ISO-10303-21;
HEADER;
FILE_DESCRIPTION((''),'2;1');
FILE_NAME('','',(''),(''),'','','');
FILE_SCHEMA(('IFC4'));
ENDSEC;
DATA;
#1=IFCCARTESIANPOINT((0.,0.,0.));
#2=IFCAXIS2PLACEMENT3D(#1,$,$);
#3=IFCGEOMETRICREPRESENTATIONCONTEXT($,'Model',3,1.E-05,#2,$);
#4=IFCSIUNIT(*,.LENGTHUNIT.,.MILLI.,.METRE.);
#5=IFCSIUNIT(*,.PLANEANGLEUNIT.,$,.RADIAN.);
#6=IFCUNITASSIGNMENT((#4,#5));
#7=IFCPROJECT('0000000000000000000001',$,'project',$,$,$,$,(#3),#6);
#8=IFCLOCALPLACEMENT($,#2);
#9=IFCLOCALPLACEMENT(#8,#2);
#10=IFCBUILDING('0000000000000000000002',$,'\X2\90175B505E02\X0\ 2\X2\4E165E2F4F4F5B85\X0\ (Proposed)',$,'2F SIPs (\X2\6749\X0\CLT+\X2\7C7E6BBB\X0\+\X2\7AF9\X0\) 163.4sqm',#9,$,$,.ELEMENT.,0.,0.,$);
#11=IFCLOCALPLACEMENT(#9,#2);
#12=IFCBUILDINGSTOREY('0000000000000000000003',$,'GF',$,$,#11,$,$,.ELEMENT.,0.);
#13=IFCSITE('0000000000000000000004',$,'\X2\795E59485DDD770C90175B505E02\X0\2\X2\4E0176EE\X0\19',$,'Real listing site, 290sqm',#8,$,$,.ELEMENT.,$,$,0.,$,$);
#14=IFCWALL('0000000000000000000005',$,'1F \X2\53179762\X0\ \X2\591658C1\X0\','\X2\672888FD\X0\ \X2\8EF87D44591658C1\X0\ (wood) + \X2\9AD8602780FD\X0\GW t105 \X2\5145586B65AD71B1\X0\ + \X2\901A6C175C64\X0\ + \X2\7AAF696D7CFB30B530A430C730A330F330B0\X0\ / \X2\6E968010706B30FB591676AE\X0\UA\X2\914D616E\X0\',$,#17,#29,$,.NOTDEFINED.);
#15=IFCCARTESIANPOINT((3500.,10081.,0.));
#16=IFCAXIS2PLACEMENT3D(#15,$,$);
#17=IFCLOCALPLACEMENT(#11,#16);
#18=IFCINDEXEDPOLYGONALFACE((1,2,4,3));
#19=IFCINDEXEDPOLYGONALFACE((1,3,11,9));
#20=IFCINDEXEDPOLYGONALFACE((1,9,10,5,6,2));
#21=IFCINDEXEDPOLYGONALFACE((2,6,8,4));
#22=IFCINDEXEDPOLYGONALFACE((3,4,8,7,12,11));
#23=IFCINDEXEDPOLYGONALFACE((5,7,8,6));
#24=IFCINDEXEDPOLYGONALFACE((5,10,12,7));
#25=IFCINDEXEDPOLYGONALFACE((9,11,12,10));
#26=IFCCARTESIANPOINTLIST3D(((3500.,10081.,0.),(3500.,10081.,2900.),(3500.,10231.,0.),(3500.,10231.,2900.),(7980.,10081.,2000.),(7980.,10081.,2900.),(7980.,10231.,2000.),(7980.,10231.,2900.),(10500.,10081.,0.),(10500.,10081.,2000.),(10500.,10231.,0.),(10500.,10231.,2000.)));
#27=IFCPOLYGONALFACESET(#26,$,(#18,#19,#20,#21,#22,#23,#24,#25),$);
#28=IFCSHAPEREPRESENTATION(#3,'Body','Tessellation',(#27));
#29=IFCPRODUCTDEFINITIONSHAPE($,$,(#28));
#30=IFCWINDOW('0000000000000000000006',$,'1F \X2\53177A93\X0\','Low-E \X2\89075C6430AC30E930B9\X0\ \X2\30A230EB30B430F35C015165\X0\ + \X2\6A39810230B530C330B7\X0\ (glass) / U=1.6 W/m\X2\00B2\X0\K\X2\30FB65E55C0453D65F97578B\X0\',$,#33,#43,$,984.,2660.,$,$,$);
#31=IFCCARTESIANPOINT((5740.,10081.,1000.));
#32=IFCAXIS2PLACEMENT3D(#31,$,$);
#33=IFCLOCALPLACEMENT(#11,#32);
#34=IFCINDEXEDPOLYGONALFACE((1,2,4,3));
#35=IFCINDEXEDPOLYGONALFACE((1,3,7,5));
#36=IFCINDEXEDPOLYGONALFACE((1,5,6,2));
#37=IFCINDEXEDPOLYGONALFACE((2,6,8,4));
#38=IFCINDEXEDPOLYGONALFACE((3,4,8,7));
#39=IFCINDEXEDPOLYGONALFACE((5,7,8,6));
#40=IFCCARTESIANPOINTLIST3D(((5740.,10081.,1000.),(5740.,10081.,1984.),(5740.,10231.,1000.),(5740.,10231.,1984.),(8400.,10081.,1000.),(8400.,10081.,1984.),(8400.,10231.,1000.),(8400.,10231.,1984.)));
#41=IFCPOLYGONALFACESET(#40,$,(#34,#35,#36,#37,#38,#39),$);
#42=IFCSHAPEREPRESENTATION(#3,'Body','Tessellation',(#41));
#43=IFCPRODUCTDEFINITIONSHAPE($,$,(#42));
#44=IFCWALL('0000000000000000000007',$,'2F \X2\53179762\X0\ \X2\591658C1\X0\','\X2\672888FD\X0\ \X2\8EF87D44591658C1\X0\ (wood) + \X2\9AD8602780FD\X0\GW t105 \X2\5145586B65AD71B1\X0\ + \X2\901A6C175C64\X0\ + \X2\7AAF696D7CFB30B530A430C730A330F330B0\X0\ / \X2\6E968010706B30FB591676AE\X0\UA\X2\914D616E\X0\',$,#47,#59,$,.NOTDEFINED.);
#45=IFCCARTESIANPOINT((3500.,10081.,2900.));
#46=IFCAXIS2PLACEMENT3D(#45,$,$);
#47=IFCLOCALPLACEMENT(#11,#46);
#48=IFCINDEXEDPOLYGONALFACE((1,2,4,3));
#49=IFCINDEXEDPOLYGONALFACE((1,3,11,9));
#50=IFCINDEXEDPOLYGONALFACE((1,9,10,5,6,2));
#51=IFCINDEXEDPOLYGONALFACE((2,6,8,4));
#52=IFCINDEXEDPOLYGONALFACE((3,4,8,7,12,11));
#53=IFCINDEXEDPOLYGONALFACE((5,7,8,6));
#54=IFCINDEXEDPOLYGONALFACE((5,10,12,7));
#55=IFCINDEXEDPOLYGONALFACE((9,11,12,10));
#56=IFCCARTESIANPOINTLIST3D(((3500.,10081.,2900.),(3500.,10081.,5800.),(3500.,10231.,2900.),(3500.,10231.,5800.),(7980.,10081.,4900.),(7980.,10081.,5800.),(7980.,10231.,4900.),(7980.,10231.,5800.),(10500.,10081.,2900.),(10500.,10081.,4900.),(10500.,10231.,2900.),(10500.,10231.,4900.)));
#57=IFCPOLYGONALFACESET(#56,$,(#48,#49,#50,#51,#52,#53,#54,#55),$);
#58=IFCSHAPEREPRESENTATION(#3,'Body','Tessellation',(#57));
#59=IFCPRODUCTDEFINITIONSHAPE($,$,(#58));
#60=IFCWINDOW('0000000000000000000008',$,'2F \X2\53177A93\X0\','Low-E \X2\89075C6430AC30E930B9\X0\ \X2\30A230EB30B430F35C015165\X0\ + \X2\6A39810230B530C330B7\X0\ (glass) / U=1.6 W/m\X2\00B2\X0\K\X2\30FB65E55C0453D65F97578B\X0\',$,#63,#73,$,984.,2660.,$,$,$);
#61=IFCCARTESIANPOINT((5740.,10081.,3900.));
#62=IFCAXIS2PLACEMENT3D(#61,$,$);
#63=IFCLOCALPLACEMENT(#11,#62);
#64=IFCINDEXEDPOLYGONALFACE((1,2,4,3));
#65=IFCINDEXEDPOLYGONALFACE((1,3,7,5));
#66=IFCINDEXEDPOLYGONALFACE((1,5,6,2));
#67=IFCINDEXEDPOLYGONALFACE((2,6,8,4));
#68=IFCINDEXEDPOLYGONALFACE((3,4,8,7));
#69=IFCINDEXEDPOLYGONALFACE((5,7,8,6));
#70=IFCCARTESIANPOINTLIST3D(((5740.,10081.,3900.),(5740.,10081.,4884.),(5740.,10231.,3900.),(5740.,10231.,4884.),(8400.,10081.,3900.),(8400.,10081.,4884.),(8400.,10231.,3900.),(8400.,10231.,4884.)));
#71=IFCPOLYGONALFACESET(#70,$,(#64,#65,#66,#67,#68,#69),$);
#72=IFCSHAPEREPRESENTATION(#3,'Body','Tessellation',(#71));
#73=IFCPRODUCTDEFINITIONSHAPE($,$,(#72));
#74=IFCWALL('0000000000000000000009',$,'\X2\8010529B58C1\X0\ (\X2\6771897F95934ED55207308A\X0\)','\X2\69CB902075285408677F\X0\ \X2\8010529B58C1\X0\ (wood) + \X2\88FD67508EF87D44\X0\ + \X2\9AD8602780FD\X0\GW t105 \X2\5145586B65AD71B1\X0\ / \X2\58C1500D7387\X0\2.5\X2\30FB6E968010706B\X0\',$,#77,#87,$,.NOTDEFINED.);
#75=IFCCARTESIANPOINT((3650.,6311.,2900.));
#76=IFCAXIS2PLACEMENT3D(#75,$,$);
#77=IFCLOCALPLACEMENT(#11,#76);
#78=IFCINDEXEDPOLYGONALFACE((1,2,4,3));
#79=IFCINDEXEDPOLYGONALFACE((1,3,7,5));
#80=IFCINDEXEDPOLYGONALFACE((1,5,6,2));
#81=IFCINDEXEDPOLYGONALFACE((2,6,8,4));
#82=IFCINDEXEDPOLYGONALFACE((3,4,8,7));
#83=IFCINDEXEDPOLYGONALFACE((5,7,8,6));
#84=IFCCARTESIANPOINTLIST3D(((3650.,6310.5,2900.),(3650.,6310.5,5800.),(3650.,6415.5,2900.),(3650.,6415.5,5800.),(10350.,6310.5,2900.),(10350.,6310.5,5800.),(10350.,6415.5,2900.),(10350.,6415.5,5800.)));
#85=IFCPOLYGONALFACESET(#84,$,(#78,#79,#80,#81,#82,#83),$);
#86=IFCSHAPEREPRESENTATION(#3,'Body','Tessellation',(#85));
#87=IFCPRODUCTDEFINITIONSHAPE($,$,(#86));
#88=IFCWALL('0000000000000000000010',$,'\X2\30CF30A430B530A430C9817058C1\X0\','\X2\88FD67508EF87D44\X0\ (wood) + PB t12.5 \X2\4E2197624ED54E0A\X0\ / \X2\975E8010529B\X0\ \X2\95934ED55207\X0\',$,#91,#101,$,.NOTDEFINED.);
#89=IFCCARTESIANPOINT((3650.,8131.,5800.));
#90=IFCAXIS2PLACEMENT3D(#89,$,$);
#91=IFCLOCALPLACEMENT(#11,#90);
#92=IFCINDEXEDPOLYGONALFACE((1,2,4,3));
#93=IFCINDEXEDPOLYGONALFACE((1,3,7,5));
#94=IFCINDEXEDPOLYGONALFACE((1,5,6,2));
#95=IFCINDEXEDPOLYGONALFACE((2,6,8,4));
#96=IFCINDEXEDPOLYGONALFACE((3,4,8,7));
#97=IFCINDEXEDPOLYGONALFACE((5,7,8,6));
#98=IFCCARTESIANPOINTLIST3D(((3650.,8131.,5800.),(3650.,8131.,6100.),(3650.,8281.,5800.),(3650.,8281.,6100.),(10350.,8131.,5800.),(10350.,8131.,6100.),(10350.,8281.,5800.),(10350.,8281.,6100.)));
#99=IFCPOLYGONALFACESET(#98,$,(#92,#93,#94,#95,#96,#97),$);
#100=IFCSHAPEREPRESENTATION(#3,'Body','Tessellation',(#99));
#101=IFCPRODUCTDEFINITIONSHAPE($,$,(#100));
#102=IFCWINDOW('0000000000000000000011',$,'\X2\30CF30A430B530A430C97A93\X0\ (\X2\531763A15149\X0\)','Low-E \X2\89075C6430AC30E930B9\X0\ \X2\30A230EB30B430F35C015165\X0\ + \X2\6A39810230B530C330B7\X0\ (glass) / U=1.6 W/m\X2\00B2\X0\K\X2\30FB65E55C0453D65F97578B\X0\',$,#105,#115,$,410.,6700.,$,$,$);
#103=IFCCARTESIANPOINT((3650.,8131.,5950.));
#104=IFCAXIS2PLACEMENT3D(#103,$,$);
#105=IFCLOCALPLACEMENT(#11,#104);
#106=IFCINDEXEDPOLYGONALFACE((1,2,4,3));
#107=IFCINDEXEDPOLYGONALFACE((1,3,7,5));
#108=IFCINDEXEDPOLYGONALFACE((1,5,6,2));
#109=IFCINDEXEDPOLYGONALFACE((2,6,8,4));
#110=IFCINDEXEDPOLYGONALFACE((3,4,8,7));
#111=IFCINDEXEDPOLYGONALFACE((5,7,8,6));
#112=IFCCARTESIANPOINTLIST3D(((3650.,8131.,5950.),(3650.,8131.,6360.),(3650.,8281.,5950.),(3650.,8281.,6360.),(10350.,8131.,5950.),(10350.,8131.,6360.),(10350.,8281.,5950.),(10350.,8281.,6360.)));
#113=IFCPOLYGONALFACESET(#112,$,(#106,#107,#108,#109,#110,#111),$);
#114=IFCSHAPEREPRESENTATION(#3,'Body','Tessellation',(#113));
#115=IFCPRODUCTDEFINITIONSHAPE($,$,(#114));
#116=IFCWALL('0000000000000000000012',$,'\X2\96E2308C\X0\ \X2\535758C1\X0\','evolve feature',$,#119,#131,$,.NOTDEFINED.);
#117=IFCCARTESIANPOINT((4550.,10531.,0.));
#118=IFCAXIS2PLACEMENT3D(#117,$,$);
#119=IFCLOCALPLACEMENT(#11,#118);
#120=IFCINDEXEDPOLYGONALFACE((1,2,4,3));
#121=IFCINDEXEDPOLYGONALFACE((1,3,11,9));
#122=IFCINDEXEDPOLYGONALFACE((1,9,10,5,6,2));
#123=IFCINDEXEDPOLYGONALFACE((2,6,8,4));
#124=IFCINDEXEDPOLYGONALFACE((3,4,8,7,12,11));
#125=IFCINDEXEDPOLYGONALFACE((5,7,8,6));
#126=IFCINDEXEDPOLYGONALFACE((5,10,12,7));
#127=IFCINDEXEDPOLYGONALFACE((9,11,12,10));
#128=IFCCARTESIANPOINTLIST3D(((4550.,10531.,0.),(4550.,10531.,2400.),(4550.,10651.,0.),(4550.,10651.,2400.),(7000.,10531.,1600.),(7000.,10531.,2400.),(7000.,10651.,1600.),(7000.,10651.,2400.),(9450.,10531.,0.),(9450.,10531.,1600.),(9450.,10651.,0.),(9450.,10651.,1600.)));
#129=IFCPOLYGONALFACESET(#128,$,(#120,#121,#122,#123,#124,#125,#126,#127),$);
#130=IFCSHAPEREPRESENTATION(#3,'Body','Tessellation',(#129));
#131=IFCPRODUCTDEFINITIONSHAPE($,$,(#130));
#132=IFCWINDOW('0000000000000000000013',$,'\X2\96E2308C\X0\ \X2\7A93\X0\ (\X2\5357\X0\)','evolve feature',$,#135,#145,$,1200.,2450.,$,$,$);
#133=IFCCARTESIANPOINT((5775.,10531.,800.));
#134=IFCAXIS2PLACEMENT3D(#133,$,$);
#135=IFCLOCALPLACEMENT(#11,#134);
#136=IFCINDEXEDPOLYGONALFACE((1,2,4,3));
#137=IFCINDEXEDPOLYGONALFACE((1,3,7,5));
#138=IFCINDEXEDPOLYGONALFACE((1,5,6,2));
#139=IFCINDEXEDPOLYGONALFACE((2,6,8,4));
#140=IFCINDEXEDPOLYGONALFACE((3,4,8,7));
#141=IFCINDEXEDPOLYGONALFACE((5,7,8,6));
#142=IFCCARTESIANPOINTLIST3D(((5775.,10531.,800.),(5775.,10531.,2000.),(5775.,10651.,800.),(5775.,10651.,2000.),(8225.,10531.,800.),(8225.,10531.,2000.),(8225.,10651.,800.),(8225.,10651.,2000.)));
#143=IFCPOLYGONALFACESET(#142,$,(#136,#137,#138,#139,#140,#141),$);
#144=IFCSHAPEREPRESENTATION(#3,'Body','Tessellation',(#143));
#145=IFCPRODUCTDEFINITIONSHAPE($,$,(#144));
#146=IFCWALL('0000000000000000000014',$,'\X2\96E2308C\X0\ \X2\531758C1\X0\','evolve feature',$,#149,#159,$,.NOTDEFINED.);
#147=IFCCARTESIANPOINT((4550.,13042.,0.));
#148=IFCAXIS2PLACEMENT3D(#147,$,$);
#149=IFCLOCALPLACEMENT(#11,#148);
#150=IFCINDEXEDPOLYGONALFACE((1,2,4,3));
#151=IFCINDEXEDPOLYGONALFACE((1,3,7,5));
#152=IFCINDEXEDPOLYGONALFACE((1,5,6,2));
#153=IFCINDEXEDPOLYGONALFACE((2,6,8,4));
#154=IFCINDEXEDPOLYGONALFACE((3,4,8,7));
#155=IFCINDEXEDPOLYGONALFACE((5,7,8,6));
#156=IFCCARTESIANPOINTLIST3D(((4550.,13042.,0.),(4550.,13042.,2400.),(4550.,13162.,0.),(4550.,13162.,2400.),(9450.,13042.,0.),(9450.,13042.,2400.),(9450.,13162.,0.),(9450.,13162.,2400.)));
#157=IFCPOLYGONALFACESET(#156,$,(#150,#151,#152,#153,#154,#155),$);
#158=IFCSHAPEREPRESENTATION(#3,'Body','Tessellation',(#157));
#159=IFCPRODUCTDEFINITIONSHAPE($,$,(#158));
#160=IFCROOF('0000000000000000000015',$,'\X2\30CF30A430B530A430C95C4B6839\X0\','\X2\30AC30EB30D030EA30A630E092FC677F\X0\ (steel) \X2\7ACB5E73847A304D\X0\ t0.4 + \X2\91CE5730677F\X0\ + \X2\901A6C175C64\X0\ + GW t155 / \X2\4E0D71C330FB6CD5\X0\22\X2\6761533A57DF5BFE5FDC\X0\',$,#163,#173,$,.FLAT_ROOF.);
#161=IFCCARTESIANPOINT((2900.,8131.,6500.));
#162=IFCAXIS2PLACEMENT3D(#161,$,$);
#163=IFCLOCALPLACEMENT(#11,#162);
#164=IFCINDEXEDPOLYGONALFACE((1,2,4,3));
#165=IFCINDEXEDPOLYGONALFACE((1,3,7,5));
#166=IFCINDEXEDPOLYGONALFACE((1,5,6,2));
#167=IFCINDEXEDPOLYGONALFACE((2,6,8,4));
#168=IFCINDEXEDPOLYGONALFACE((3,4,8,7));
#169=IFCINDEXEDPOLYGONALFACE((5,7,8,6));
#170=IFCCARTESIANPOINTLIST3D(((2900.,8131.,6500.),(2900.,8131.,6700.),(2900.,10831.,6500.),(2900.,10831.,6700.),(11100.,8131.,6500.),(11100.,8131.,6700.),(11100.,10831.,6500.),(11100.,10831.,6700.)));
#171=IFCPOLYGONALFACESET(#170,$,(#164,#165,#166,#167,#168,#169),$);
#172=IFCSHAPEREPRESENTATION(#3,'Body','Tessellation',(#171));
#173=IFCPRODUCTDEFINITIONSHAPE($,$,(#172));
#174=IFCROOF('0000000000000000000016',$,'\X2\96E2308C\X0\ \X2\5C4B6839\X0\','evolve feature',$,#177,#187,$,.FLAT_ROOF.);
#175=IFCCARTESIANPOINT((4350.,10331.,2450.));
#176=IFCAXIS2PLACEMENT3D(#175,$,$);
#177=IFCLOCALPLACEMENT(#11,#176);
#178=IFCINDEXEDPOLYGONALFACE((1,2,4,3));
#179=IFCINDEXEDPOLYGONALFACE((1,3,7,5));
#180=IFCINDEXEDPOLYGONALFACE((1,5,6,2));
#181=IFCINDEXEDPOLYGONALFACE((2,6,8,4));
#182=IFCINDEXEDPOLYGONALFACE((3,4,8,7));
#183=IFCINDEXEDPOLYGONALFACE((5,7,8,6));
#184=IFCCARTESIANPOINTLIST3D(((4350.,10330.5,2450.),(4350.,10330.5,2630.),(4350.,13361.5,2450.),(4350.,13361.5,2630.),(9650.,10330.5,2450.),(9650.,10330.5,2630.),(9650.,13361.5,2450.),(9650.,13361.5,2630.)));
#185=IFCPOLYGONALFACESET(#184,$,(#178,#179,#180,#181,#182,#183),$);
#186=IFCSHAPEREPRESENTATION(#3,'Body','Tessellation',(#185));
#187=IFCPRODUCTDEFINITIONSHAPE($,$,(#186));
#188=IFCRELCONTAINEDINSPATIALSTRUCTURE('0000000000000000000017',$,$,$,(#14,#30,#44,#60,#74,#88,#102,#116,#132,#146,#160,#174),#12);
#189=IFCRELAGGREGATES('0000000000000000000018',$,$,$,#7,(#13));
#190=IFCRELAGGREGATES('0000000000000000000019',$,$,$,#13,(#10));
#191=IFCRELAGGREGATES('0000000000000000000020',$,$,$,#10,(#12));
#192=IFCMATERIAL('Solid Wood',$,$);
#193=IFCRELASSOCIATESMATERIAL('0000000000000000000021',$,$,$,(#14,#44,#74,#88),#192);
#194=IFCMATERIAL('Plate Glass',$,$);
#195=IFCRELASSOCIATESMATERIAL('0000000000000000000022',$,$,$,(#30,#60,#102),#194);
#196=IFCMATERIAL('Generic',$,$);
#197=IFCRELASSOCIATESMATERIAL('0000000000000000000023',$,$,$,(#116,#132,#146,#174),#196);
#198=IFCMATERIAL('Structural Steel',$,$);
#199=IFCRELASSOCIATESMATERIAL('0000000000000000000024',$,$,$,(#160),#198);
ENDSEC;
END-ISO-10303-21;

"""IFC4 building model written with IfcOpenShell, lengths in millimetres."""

from ifc_helpers import new_model, si_unit, frame, frame_2d, origin, place, context, project, spatial, rectangle, extrude, material, element, fill, save


model = new_model("IFC4")

# Units and contexts
model_context = context("Model", 3, precision=1e-05, world=origin())
ifc_project = project(units=[si_unit("LENGTHUNIT", "METRE", prefix="MILLI"), si_unit("PLANEANGLEUNIT", "RADIAN")], contexts=[model_context])

# Site, building, storey
site_placement = place(None, origin())
site = spatial("IfcSite", under=ifc_project, at=site_placement, Name="神奈川県逗子市2丁目19", ObjectType="Real listing site, 290sqm", CompositionType="ELEMENT", RefElevation=0.0)
building_placement = place(site_placement, origin())
building = spatial("IfcBuilding", under=site, at=building_placement, Name="逗子市 2世帯住宅 (Proposed)", ObjectType="2F SIPs (杉CLT+籾殻+竹) 163.4sqm", CompositionType="ELEMENT", ElevationOfRefHeight=0.0, ElevationOfTerrain=0.0)
storey_placement = place(building_placement, origin())
storey = spatial("IfcBuildingStorey", under=building, at=storey_placement, Name="GF", CompositionType="ELEMENT", Elevation=0.0)

# Shared definitions
ifc_material_1 = material(Name="Generic")

# Wall, opening, window
ifc_material_2 = material(Name="Solid Wood")
wall_1_placement = place(storey_placement, frame((3500.0, 10081.0, 0.0)))
wall_1 = element("IfcWall", 1, at=wall_1_placement, inside=storey, material=ifc_material_2, Name="1F 北面 外壁", Description="木製 軸組外壁 (wood) + 高性能GW t105 充填断熱 + 通気層 + 窯業系サイディング / 準耐火・外皮UA配慮", PredefinedType="NOTDEFINED", context=model_context, shape_type="SweptSolid", body=[
    extrude(rectangle(XDim=7000.0, YDim=150.0, at=frame_2d((3500.0, 75.0))), frame((3500.0, 10081.0, 0.0)), (0.0, 0.0, 1.0), 2900.0),
])
opening_1_placement = place(storey_placement, frame((5740.0, 10081.0, 1000.0)))
opening_1 = element("IfcOpeningElement", 2, at=opening_1_placement, cuts=wall_1, PredefinedType="NOTDEFINED", context=model_context, shape_type="SweptSolid", body=[
    extrude(rectangle(XDim=2660.0, YDim=150.0, at=frame_2d((1330.0, 75.0))), frame((5740.0, 10081.0, 1000.0)), (0.0, 0.0, 1.0), 984.0),
])
ifc_material_3 = material(Name="Plate Glass")
window_1_placement = place(storey_placement, frame((5740.0, 10081.0, 1000.0)))
window_1 = element("IfcWindow", 3, at=window_1_placement, inside=storey, material=ifc_material_3, Name="1F 北窓", Description="Low-E 複層ガラス アルゴン封入 + 樹脂サッシ (glass) / U=1.6 W/m²K・日射取得型", OverallHeight=984.0, OverallWidth=2660.0, context=model_context, shape_type="SweptSolid", body=[
    extrude(rectangle(XDim=2660.0, YDim=150.0, at=frame_2d((1330.0, 75.0))), frame((5740.0, 10081.0, 1000.0)), (0.0, 0.0, 1.0), 984.0),
])
fill(opening_1, window_1)

# Wall, opening, window
wall_2_placement = place(storey_placement, frame((3500.0, 10081.0, 2900.0)))
wall_2 = element("IfcWall", 4, at=wall_2_placement, inside=storey, material=ifc_material_2, Name="2F 北面 外壁", Description="木製 軸組外壁 (wood) + 高性能GW t105 充填断熱 + 通気層 + 窯業系サイディング / 準耐火・外皮UA配慮", PredefinedType="NOTDEFINED", context=model_context, shape_type="SweptSolid", body=[
    extrude(rectangle(XDim=7000.0, YDim=150.0, at=frame_2d((3500.0, 75.0))), frame((3500.0, 10081.0, 2900.0)), (0.0, 0.0, 1.0), 2900.0),
])
opening_2_placement = place(storey_placement, frame((5740.0, 10081.0, 3900.0)))
opening_2 = element("IfcOpeningElement", 5, at=opening_2_placement, cuts=wall_2, PredefinedType="NOTDEFINED", context=model_context, shape_type="SweptSolid", body=[
    extrude(rectangle(XDim=2660.0, YDim=150.0, at=frame_2d((1330.0, 75.0))), frame((5740.0, 10081.0, 3900.0)), (0.0, 0.0, 1.0), 984.0),
])
window_2_placement = place(storey_placement, frame((5740.0, 10081.0, 3900.0)))
window_2 = element("IfcWindow", 6, at=window_2_placement, inside=storey, material=ifc_material_3, Name="2F 北窓", Description="Low-E 複層ガラス アルゴン封入 + 樹脂サッシ (glass) / U=1.6 W/m²K・日射取得型", OverallHeight=984.0, OverallWidth=2660.0, context=model_context, shape_type="SweptSolid", body=[
    extrude(rectangle(XDim=2660.0, YDim=150.0, at=frame_2d((1330.0, 75.0))), frame((5740.0, 10081.0, 3900.0)), (0.0, 0.0, 1.0), 984.0),
])
fill(opening_2, window_2)

# Wall
wall_3_placement = place(storey_placement, frame((3650.0, 6311.0, 2900.0)))
element("IfcWall", 7, at=wall_3_placement, inside=storey, material=ifc_material_2, Name="耐力壁 (東西間仕切り)", Description="構造用合板 耐力壁 (wood) + 製材軸組 + 高性能GW t105 充填断熱 / 壁倍率2.5・準耐火", PredefinedType="NOTDEFINED", context=model_context, shape_type="SweptSolid", body=[
    extrude(rectangle(XDim=6700.0, YDim=105.0, at=frame_2d((3350.0, 52.0))), frame((3650.0, 6311.0, 2900.0)), (0.0, 0.0, 1.0), 2900.0),
])

# Walls, openings, windows
wall_4_placement = place(storey_placement, frame((3650.0, 8131.0, 5800.0)))
wall_4 = element("IfcWall", 8, at=wall_4_placement, inside=storey, material=ifc_material_2, Name="ハイサイド腰壁", Description="製材軸組 (wood) + PB t12.5 両面仕上 / 非耐力 間仕切", PredefinedType="NOTDEFINED", context=model_context, shape_type="SweptSolid", body=[
    extrude(rectangle(XDim=6700.0, YDim=150.0, at=frame_2d((3350.0, 75.0))), frame((3650.0, 8131.0, 5800.0)), (0.0, 0.0, 1.0), 700.0),
])
opening_3_placement = place(storey_placement, frame((3650.0, 8131.0, 5950.0)))
opening_3 = element("IfcOpeningElement", 9, at=opening_3_placement, cuts=wall_4, PredefinedType="NOTDEFINED", context=model_context, shape_type="SweptSolid", body=[
    extrude(rectangle(XDim=6700.0, YDim=150.0, at=frame_2d((3350.0, 75.0))), frame((3650.0, 8131.0, 5950.0)), (0.0, 0.0, 1.0), 410.0),
])
window_3_placement = place(storey_placement, frame((3650.0, 8131.0, 5950.0)))
window_3 = element("IfcWindow", 10, at=window_3_placement, inside=storey, material=ifc_material_3, Name="ハイサイド窓 (北採光)", Description="Low-E 複層ガラス アルゴン封入 + 樹脂サッシ (glass) / U=1.6 W/m²K・日射取得型", OverallHeight=410.0, OverallWidth=6700.0, context=model_context, shape_type="SweptSolid", body=[
    extrude(rectangle(XDim=6700.0, YDim=150.0, at=frame_2d((3350.0, 75.0))), frame((3650.0, 8131.0, 5950.0)), (0.0, 0.0, 1.0), 410.0),
])
fill(opening_3, window_3)
wall_5_placement = place(storey_placement, frame((4550.0, 10531.0, 0.0)))
wall_5 = element("IfcWall", 11, at=wall_5_placement, inside=storey, material=ifc_material_1, Name="離れ 南壁", Description="evolve feature", PredefinedType="NOTDEFINED", context=model_context, shape_type="SweptSolid", body=[
    extrude(rectangle(XDim=4900.0, YDim=120.0, at=frame_2d((2450.0, 60.0))), frame((4550.0, 10531.0, 0.0)), (0.0, 0.0, 1.0), 2400.0),
])
opening_4_placement = place(storey_placement, frame((5775.0, 10531.0, 800.0)))
opening_4 = element("IfcOpeningElement", 12, at=opening_4_placement, cuts=wall_5, PredefinedType="NOTDEFINED", context=model_context, shape_type="SweptSolid", body=[
    extrude(rectangle(XDim=2450.0, YDim=120.0, at=frame_2d((1225.0, 60.0))), frame((5775.0, 10531.0, 800.0)), (0.0, 0.0, 1.0), 1200.0),
])
window_4_placement = place(storey_placement, frame((5775.0, 10531.0, 800.0)))
window_4 = element("IfcWindow", 13, at=window_4_placement, inside=storey, material=ifc_material_1, Name="離れ 窓 (南)", Description="evolve feature", OverallHeight=1200.0, OverallWidth=2450.0, context=model_context, shape_type="SweptSolid", body=[
    extrude(rectangle(XDim=2450.0, YDim=120.0, at=frame_2d((1225.0, 60.0))), frame((5775.0, 10531.0, 800.0)), (0.0, 0.0, 1.0), 1200.0),
])
fill(opening_4, window_4)

# Wall
wall_6_placement = place(storey_placement, frame((4550.0, 13042.0, 0.0)))
element("IfcWall", 14, at=wall_6_placement, inside=storey, material=ifc_material_1, Name="離れ 北壁", Description="evolve feature", PredefinedType="NOTDEFINED", context=model_context, shape_type="SweptSolid", body=[
    extrude(rectangle(XDim=4900.0, YDim=120.0, at=frame_2d((2450.0, 60.0))), frame((4550.0, 13042.0, 0.0)), (0.0, 0.0, 1.0), 2400.0),
])

# Roofs
ifc_material_4 = material(Name="Structural Steel")
roof_1_placement = place(storey_placement, frame((2900.0, 8131.0, 6500.0)))
element("IfcRoof", 15, at=roof_1_placement, inside=storey, material=ifc_material_4, Name="ハイサイド屋根", Description="ガルバリウム鋼板 (steel) 立平葺き t0.4 + 野地板 + 通気層 + GW t155 / 不燃・法22条区域対応", PredefinedType="FLAT_ROOF", context=model_context, shape_type="SweptSolid", body=[
    extrude(rectangle(XDim=8200.0, YDim=2700.0, at=frame_2d((4100.0, 1350.0))), frame((2900.0, 8131.0, 6500.0)), (0.0, 0.0, 1.0), 200.0),
])
roof_2_placement = place(storey_placement, frame((4350.0, 10331.0, 2450.0)))
element("IfcRoof", 16, at=roof_2_placement, inside=storey, material=ifc_material_1, Name="離れ 屋根", Description="evolve feature", PredefinedType="FLAT_ROOF", context=model_context, shape_type="SweptSolid", body=[
    extrude(rectangle(XDim=5300.0, YDim=3031.0, at=frame_2d((2650.0, 1515.0))), frame((4350.0, 10331.0, 2450.0)), (0.0, 0.0, 1.0), 180.0),
])

save(model, "model.ifc")
